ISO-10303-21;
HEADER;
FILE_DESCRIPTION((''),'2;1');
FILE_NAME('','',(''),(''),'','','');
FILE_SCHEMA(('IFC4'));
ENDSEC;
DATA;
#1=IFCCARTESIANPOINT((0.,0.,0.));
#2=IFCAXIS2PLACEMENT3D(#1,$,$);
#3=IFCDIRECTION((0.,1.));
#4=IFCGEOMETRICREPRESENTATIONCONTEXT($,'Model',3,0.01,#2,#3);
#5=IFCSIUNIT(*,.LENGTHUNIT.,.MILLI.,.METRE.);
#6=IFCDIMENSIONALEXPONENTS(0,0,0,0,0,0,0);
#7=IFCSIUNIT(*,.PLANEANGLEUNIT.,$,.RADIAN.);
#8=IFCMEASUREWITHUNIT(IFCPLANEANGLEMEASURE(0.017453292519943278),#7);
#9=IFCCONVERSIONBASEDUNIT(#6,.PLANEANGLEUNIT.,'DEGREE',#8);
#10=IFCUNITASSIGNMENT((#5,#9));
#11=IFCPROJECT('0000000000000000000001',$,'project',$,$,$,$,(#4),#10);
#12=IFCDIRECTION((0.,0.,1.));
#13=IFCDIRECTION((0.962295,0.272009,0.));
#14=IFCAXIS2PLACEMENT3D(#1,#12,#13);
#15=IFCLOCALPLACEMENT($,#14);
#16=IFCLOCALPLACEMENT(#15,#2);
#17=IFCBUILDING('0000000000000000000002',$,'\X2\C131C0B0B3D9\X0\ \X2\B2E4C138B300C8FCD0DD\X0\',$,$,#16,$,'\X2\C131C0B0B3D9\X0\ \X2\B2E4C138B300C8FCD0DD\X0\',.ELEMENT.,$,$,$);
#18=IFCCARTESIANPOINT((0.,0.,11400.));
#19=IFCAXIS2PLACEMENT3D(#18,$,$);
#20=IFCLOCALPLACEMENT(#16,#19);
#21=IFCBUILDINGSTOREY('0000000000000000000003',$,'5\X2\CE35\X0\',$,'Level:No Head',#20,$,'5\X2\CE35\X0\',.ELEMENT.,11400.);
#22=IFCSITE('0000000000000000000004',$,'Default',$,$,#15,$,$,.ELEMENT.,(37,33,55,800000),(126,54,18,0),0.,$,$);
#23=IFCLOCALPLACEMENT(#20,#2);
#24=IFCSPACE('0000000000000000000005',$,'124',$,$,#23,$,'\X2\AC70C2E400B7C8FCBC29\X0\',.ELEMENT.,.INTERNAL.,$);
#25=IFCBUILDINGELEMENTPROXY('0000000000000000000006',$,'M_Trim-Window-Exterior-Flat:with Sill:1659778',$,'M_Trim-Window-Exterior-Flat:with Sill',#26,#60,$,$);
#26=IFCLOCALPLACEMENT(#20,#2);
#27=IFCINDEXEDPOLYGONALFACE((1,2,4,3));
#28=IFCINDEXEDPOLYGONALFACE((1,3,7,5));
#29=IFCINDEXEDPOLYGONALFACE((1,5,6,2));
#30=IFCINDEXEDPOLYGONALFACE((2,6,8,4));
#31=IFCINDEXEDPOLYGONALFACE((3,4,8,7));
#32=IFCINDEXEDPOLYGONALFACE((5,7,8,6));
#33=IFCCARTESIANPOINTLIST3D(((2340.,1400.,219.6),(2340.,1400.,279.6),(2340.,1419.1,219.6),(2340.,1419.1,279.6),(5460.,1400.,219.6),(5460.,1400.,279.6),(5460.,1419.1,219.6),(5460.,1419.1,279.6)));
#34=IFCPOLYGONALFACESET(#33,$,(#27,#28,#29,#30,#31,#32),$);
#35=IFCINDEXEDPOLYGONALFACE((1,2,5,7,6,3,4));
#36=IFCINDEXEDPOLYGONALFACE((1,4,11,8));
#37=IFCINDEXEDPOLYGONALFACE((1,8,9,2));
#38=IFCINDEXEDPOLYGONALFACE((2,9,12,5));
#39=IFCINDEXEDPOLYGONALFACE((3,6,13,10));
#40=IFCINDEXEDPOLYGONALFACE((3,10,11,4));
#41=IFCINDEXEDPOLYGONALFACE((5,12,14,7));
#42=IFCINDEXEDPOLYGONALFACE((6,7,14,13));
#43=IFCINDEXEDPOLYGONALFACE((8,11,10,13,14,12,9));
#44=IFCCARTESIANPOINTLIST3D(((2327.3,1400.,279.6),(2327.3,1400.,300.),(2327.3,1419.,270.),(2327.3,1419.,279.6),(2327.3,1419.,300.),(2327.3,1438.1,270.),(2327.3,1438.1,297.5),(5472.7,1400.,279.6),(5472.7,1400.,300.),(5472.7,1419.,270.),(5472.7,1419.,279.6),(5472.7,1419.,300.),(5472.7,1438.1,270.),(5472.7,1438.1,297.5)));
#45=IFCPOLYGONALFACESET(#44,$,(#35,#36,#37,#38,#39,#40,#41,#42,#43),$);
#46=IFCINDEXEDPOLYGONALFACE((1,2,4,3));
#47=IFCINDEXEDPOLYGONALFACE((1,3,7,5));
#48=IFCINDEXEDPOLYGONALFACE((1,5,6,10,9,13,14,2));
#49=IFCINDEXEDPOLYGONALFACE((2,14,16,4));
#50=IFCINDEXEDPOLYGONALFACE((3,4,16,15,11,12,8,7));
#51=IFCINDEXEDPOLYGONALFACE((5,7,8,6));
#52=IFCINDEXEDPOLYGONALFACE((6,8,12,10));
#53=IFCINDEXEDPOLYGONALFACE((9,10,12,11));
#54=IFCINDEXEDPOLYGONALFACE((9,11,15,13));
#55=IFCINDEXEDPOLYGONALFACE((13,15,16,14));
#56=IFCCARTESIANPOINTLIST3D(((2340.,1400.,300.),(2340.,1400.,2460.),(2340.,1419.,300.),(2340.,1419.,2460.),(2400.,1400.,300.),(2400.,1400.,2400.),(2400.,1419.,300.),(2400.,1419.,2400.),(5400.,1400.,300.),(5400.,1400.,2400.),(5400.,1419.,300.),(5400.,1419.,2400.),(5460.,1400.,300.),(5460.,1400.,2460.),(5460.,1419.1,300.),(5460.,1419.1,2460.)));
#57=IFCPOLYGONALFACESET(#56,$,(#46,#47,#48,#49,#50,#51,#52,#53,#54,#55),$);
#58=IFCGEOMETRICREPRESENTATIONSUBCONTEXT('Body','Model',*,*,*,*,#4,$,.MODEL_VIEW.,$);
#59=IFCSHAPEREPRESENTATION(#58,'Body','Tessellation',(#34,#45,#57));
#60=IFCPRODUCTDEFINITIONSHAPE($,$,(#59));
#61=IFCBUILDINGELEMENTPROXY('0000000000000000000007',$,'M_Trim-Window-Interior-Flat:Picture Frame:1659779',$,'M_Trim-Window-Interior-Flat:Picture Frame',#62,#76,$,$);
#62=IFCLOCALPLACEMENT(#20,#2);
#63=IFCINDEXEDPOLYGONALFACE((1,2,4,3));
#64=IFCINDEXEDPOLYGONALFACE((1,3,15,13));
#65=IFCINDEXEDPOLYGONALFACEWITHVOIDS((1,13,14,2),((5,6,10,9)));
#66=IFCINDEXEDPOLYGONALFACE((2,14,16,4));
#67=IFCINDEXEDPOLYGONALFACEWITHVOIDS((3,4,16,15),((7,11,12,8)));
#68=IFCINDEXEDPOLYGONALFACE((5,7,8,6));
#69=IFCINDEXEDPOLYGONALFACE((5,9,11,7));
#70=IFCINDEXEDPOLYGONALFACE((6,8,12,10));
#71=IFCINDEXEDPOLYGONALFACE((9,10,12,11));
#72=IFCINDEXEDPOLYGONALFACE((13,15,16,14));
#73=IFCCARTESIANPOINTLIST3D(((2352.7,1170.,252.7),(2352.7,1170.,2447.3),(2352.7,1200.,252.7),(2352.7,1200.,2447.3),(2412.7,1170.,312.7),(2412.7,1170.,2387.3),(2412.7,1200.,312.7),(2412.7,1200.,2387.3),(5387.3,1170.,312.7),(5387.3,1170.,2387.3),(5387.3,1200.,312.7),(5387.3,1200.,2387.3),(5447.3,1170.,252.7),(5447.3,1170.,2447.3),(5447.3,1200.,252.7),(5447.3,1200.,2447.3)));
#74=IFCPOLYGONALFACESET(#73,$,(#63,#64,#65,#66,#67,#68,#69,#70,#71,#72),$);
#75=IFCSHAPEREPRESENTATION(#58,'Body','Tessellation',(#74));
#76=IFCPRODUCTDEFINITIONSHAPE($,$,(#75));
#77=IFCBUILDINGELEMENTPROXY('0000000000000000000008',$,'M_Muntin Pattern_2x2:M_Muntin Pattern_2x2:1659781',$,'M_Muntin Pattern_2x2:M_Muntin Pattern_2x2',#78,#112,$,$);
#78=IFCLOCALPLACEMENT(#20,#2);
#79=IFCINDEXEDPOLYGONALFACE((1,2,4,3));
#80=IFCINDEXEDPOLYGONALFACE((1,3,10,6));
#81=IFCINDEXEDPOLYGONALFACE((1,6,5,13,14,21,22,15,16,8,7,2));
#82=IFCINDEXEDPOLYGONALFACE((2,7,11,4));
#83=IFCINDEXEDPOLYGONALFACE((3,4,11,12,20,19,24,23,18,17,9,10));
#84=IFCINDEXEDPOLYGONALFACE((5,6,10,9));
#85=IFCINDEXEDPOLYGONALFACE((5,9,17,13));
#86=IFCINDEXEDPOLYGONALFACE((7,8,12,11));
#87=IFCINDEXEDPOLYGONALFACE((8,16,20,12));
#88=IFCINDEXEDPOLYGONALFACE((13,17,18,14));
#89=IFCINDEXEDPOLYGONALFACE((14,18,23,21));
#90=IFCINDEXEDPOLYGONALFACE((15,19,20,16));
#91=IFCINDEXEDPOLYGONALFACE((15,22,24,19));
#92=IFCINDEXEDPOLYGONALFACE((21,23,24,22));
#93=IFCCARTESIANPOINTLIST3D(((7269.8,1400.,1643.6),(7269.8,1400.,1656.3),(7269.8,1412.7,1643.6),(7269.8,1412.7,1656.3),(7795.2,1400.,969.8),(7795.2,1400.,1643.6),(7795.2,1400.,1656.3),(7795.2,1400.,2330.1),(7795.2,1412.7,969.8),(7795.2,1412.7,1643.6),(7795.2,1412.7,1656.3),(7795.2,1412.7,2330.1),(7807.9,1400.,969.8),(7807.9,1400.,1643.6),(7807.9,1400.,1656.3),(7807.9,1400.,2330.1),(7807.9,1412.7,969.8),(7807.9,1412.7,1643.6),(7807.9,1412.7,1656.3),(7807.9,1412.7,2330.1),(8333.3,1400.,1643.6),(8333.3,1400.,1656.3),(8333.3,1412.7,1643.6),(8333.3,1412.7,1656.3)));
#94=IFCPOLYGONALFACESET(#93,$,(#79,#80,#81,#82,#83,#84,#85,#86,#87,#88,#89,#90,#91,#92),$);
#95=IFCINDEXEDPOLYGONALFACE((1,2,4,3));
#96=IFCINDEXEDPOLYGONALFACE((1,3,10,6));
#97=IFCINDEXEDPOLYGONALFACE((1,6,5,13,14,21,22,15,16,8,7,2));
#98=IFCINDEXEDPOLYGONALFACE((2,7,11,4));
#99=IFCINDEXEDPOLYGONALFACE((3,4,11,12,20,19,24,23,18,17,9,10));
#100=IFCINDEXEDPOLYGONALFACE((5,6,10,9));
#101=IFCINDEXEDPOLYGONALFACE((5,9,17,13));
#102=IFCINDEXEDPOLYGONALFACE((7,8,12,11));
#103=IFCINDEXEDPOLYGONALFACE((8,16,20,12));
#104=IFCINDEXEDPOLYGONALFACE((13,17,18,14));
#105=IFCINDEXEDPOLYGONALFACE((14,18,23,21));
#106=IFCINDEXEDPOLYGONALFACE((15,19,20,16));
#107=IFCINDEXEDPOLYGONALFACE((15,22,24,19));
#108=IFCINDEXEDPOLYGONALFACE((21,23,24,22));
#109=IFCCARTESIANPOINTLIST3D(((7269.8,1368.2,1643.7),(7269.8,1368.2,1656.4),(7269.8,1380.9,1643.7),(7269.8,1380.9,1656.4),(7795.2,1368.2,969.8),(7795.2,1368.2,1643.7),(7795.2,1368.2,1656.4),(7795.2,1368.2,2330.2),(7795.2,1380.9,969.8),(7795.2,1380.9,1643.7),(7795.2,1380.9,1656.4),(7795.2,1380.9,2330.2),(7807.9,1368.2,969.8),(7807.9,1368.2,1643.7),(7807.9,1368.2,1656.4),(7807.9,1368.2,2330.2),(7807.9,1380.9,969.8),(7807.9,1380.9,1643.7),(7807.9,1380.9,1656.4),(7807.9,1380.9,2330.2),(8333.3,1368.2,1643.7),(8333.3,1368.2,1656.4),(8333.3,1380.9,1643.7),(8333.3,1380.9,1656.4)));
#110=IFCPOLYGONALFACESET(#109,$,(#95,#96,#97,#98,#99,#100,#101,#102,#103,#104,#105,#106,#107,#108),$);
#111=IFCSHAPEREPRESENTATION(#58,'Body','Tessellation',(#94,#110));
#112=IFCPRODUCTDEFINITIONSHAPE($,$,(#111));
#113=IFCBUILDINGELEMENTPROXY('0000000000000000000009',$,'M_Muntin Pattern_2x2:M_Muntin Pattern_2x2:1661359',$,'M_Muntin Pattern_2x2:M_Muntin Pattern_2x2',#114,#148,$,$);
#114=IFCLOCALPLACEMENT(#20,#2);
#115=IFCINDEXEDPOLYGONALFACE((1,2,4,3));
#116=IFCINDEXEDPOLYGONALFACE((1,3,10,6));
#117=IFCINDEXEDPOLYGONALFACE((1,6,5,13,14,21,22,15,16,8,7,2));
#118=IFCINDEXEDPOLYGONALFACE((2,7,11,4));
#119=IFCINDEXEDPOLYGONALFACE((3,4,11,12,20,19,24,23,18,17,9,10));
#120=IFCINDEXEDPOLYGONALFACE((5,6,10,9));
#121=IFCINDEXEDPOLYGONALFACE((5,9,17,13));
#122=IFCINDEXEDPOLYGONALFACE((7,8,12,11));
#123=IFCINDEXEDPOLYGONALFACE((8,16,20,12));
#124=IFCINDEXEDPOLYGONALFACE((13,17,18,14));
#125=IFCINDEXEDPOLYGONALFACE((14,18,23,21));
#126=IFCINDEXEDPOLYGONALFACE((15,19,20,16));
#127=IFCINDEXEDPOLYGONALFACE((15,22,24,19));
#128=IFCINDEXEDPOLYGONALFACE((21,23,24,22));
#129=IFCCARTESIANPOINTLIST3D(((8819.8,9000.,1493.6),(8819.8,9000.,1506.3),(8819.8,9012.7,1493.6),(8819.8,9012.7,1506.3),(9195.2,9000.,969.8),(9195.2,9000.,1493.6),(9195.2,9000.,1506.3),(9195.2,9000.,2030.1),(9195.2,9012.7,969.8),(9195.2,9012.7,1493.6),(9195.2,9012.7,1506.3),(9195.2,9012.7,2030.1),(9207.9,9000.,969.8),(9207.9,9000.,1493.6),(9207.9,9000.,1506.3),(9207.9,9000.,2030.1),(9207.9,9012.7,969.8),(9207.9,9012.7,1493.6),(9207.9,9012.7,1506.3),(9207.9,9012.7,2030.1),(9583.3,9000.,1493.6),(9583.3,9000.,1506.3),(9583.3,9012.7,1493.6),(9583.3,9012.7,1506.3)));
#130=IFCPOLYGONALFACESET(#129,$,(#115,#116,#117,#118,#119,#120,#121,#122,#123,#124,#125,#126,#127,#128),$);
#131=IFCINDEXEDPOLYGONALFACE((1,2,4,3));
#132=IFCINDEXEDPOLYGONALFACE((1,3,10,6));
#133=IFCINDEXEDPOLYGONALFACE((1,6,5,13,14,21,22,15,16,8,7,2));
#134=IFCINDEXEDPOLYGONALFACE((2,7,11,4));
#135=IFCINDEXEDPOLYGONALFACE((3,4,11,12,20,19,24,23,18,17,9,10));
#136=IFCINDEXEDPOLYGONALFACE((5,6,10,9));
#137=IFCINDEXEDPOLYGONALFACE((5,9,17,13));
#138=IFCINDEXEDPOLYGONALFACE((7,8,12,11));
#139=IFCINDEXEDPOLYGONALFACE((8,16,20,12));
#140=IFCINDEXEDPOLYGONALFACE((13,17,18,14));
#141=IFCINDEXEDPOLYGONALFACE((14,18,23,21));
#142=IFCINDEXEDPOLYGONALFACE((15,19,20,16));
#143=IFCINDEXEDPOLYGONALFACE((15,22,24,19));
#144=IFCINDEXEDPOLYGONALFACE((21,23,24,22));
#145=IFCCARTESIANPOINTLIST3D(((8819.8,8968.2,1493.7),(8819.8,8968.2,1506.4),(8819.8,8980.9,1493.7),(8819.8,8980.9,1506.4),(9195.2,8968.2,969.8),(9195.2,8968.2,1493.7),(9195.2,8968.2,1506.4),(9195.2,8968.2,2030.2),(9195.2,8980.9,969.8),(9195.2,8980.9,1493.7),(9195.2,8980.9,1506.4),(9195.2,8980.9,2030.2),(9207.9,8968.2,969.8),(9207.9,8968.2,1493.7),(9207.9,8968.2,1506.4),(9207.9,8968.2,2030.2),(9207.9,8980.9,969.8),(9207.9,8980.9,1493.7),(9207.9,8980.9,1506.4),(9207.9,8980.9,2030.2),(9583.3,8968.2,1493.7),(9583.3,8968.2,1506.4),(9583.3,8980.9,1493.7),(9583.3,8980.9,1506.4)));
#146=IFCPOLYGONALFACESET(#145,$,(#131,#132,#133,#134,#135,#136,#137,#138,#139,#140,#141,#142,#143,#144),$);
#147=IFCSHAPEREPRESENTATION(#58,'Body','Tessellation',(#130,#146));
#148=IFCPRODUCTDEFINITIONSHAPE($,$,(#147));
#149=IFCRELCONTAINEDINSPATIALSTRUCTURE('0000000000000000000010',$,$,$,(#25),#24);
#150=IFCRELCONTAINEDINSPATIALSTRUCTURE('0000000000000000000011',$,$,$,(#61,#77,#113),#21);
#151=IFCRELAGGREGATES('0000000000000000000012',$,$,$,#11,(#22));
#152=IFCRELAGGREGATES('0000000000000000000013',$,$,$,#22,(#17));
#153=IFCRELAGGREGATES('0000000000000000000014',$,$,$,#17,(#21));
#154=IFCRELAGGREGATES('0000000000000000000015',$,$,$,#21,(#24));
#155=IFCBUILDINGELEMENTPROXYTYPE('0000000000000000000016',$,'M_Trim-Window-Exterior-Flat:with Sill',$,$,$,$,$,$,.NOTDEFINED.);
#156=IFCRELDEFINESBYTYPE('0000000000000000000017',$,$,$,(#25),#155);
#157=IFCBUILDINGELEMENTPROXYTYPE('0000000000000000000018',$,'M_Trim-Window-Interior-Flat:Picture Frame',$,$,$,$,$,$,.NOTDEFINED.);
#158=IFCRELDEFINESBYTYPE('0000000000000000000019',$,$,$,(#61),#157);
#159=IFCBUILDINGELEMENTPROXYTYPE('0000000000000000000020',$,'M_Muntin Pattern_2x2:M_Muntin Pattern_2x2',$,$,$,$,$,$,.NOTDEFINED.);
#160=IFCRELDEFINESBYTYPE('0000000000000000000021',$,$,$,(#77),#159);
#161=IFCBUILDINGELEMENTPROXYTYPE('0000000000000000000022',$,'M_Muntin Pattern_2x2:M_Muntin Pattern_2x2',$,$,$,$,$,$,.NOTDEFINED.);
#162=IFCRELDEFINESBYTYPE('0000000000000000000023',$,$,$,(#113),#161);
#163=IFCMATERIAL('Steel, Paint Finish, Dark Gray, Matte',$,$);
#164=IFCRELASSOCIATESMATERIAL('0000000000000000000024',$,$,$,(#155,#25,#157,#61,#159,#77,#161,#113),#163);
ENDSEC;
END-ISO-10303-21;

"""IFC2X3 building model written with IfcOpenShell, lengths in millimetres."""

from ifc_helpers import new_model, entity, si_unit, converted_unit, direction, frame, frame_2d, origin, place, context, subcontext, project, spatial, polyline, rectangle, outline, extrude, source, transform, mapped, material, type_object, type_shapes, element, save


model = new_model("IFC2X3")

# Units and contexts
model_context = context("Model", 3, precision=0.01, world=origin(), true_north=direction((0.0, 1.0)))
body_context = subcontext(model_context, "Body", "Model", "MODEL_VIEW")
ifc_project = project(units=[si_unit("LENGTHUNIT", "METRE", prefix="MILLI"), converted_unit("PLANEANGLEUNIT", "DEGREE", entity("IfcPlaneAngleMeasure", 0.017453292519943278), si_unit("PLANEANGLEUNIT", "RADIAN"), dimensions=[0, 0, 0, 0, 0, 0, 0])], contexts=[model_context])

# Site, building, storey
site_placement = place(None, frame((0.0, 0.0, 0.0), z_axis=(0.0, 0.0, 1.0), x_axis=(0.962295, 0.272009, 0.0)))
site = spatial("IfcSite", under=ifc_project, at=site_placement, Name="Default", CompositionType="ELEMENT", RefLatitude=(37, 33, 55, 800000), RefLongitude=(126, 54, 18, 0), RefElevation=0.0)
building_placement = place(site_placement, origin())
building = spatial("IfcBuilding", under=site, at=building_placement, Name="성산동 다세대주택", LongName="성산동 다세대주택", CompositionType="ELEMENT")
storey_placement = place(building_placement, frame((0.0, 0.0, 11400.0)))
storey = spatial("IfcBuildingStorey", under=building, at=storey_placement, Name="5층", ObjectType="Level:No Head", LongName="5층", CompositionType="ELEMENT", Elevation=11400.0)

# Shared definitions
space_1_placement = place(storey_placement, origin())
space_1 = spatial("IfcSpace", under=storey, at=space_1_placement, Name="124", LongName="거실·주방", CompositionType="ELEMENT", InteriorOrExteriorSpace="INTERNAL")

# Building element proxies
ifc_material_1 = material(Name="Steel, Paint Finish, Dark Gray, Matte")
building_element_proxy_type_1 = type_object("IfcBuildingElementProxyType", Name="M_Trim-Window-Exterior-Flat:with Sill", PredefinedType="NOTDEFINED", material=ifc_material_1)
shared_shape_1 = source(origin(), body_context, "Body", "SweptSolid", [
    extrude(rectangle(XDim=3120.0, YDim=60.0, at=frame_2d((0.0, 0.0), x_axis=(1.0, 0.0))), frame((0.0, -2150.4, 0.0), z_axis=(0.0, 0.0, 1.0), x_axis=(-1.0, 0.0, 0.0)), (0.0, 0.0, 1.0), 19.0),
    extrude(outline(polyline([(-19.0, -15.2), (0.0, -15.2), (0.0, -5.7), (19.0, -5.7), (19.0, 14.8), (0.0, 14.8), (-19.0, 12.3), (-19.0, -15.2)])), frame((-1572.7, -2114.8, 19.0), z_axis=(1.0, 0.0, 0.0), x_axis=(0.0, 0.0, -1.0)), (0.0, 0.0, 1.0), 3145.4),
    extrude(outline(polyline([(-1095.0, -1560.0), (1065.0, -1560.0), (1065.0, -1500.0), (-1035.0, -1500.0), (-1035.0, 1500.0), (1065.0, 1500.0), (1065.0, 1560.0), (-1095.0, 1560.0), (-1095.0, -1560.0)])), frame((0.0, -1035.0, 0.0), z_axis=(0.0, 0.0, 1.0), x_axis=(0.0, -1.0, 0.0)), (0.0, 0.0, 1.0), 19.0),
])
type_shapes(building_element_proxy_type_1, [shared_shape_1])
proxy_1_placement = place(space_1_placement, frame((3900.0, 1400.0, 2400.0), z_axis=(0.0, 1.0, 0.0), x_axis=(-1.0, 0.0, 0.0)))
element("IfcBuildingElementProxy", 1, at=proxy_1_placement, inside=space_1, type_object=building_element_proxy_type_1, material=ifc_material_1, Name="M_Trim-Window-Exterior-Flat:with Sill:1659778", ObjectType="M_Trim-Window-Exterior-Flat:with Sill", context=body_context, shape_type="MappedRepresentation", body=[
    mapped(shared_shape_1, transform((0.0, 0.0, 0.0), scale=1.0)),
])
building_element_proxy_type_2 = type_object("IfcBuildingElementProxyType", Name="M_Trim-Window-Interior-Flat:Picture Frame", PredefinedType="NOTDEFINED", material=ifc_material_1)
shared_shape_2 = source(origin(), body_context, "Body", "SweptSolid", [
    extrude(outline(polyline([(-1547.3, -1097.3), (1547.3, -1097.3), (1547.3, 1097.3), (-1547.3, 1097.3), (-1547.3, -1097.3)]), holes=[polyline([(-1487.3, -1037.3), (-1487.3, 1037.3), (1487.3, 1037.3), (1487.3, -1037.3), (-1487.3, -1037.3)])]), frame((0.0, -1050.0, 0.0), z_axis=(0.0, 0.0, 1.0), x_axis=(-1.0, 0.0, 0.0)), (0.0, 0.0, 1.0), 30.0),
])
type_shapes(building_element_proxy_type_2, [shared_shape_2])
proxy_2_placement = place(storey_placement, frame((3900.0, 1200.0, 2400.0), z_axis=(0.0, -1.0, 0.0), x_axis=(1.0, 0.0, 0.0)))
element("IfcBuildingElementProxy", 2, at=proxy_2_placement, inside=storey, type_object=building_element_proxy_type_2, material=ifc_material_1, Name="M_Trim-Window-Interior-Flat:Picture Frame:1659779", ObjectType="M_Trim-Window-Interior-Flat:Picture Frame", context=body_context, shape_type="MappedRepresentation", body=[
    mapped(shared_shape_2, transform((0.0, 0.0, 0.0), scale=1.0)),
])
building_element_proxy_type_3 = type_object("IfcBuildingElementProxyType", Name="M_Muntin Pattern_2x2:M_Muntin Pattern_2x2", PredefinedType="NOTDEFINED", material=ifc_material_1)
shared_shape_3 = source(origin(), body_context, "Body", "SweptSolid", [
    extrude(outline(polyline([(6.4, -6.4), (680.1, -6.4), (680.1, 6.3), (6.4, 6.3), (6.4, 531.7), (-6.3, 531.7), (-6.3, 6.3), (-680.2, 6.3), (-680.2, -6.4), (-6.3, -6.4), (-6.3, -531.7), (6.4, -531.7), (6.4, -6.4)])), frame((0.0, 9.5, 680.1), z_axis=(0.0, 1.0, 0.0), x_axis=(0.0, 0.0, 1.0)), (0.0, 0.0, 1.0), 12.7),
    extrude(outline(polyline([(6.4, -6.4), (680.2, -6.4), (680.2, 6.3), (6.4, 6.3), (6.4, 531.7), (-6.3, 531.7), (-6.3, 6.3), (-680.2, 6.3), (-680.2, -6.4), (-6.3, -6.4), (-6.3, -531.7), (6.4, -531.7), (6.4, -6.4)])), frame((0.0, -22.2, 680.2), z_axis=(0.0, 1.0, 0.0), x_axis=(0.0, 0.0, 1.0)), (0.0, 0.0, 1.0), 12.7),
])
type_shapes(building_element_proxy_type_3, [shared_shape_3])
proxy_3_placement = place(storey_placement, frame((7801.6, 1390.5, 969.8)))
element("IfcBuildingElementProxy", 3, at=proxy_3_placement, inside=storey, type_object=building_element_proxy_type_3, material=ifc_material_1, Name="M_Muntin Pattern_2x2:M_Muntin Pattern_2x2:1659781", ObjectType="M_Muntin Pattern_2x2:M_Muntin Pattern_2x2", context=body_context, shape_type="MappedRepresentation", body=[
    mapped(shared_shape_3, transform((0.0, 0.0, 0.0), scale=1.0)),
])
building_element_proxy_type_4 = type_object("IfcBuildingElementProxyType", Name="M_Muntin Pattern_2x2:M_Muntin Pattern_2x2", PredefinedType="NOTDEFINED", material=ifc_material_1)
shared_shape_4 = source(origin(), body_context, "Body", "SweptSolid", [
    extrude(outline(polyline([(6.4, -6.4), (530.1, -6.4), (530.1, 6.3), (6.4, 6.3), (6.4, 381.7), (-6.3, 381.7), (-6.3, 6.3), (-530.2, 6.3), (-530.2, -6.4), (-6.3, -6.4), (-6.3, -381.7), (6.4, -381.7), (6.4, -6.4)])), frame((0.0, 9.5, 530.1), z_axis=(0.0, 1.0, 0.0), x_axis=(0.0, 0.0, 1.0)), (0.0, 0.0, 1.0), 12.7),
    extrude(outline(polyline([(6.4, -6.4), (530.2, -6.4), (530.2, 6.3), (6.4, 6.3), (6.4, 381.7), (-6.3, 381.7), (-6.3, 6.3), (-530.2, 6.3), (-530.2, -6.4), (-6.3, -6.4), (-6.3, -381.7), (6.4, -381.7), (6.4, -6.4)])), frame((0.0, -22.2, 530.2), z_axis=(0.0, 1.0, 0.0), x_axis=(0.0, 0.0, 1.0)), (0.0, 0.0, 1.0), 12.7),
])
type_shapes(building_element_proxy_type_4, [shared_shape_4])
proxy_4_placement = place(storey_placement, frame((9201.6, 8990.5, 969.8)))
element("IfcBuildingElementProxy", 4, at=proxy_4_placement, inside=storey, type_object=building_element_proxy_type_4, material=ifc_material_1, Name="M_Muntin Pattern_2x2:M_Muntin Pattern_2x2:1661359", ObjectType="M_Muntin Pattern_2x2:M_Muntin Pattern_2x2", context=body_context, shape_type="MappedRepresentation", body=[
    mapped(shared_shape_4, transform((0.0, 0.0, 0.0), scale=1.0)),
])

save(model, "model.ifc")
